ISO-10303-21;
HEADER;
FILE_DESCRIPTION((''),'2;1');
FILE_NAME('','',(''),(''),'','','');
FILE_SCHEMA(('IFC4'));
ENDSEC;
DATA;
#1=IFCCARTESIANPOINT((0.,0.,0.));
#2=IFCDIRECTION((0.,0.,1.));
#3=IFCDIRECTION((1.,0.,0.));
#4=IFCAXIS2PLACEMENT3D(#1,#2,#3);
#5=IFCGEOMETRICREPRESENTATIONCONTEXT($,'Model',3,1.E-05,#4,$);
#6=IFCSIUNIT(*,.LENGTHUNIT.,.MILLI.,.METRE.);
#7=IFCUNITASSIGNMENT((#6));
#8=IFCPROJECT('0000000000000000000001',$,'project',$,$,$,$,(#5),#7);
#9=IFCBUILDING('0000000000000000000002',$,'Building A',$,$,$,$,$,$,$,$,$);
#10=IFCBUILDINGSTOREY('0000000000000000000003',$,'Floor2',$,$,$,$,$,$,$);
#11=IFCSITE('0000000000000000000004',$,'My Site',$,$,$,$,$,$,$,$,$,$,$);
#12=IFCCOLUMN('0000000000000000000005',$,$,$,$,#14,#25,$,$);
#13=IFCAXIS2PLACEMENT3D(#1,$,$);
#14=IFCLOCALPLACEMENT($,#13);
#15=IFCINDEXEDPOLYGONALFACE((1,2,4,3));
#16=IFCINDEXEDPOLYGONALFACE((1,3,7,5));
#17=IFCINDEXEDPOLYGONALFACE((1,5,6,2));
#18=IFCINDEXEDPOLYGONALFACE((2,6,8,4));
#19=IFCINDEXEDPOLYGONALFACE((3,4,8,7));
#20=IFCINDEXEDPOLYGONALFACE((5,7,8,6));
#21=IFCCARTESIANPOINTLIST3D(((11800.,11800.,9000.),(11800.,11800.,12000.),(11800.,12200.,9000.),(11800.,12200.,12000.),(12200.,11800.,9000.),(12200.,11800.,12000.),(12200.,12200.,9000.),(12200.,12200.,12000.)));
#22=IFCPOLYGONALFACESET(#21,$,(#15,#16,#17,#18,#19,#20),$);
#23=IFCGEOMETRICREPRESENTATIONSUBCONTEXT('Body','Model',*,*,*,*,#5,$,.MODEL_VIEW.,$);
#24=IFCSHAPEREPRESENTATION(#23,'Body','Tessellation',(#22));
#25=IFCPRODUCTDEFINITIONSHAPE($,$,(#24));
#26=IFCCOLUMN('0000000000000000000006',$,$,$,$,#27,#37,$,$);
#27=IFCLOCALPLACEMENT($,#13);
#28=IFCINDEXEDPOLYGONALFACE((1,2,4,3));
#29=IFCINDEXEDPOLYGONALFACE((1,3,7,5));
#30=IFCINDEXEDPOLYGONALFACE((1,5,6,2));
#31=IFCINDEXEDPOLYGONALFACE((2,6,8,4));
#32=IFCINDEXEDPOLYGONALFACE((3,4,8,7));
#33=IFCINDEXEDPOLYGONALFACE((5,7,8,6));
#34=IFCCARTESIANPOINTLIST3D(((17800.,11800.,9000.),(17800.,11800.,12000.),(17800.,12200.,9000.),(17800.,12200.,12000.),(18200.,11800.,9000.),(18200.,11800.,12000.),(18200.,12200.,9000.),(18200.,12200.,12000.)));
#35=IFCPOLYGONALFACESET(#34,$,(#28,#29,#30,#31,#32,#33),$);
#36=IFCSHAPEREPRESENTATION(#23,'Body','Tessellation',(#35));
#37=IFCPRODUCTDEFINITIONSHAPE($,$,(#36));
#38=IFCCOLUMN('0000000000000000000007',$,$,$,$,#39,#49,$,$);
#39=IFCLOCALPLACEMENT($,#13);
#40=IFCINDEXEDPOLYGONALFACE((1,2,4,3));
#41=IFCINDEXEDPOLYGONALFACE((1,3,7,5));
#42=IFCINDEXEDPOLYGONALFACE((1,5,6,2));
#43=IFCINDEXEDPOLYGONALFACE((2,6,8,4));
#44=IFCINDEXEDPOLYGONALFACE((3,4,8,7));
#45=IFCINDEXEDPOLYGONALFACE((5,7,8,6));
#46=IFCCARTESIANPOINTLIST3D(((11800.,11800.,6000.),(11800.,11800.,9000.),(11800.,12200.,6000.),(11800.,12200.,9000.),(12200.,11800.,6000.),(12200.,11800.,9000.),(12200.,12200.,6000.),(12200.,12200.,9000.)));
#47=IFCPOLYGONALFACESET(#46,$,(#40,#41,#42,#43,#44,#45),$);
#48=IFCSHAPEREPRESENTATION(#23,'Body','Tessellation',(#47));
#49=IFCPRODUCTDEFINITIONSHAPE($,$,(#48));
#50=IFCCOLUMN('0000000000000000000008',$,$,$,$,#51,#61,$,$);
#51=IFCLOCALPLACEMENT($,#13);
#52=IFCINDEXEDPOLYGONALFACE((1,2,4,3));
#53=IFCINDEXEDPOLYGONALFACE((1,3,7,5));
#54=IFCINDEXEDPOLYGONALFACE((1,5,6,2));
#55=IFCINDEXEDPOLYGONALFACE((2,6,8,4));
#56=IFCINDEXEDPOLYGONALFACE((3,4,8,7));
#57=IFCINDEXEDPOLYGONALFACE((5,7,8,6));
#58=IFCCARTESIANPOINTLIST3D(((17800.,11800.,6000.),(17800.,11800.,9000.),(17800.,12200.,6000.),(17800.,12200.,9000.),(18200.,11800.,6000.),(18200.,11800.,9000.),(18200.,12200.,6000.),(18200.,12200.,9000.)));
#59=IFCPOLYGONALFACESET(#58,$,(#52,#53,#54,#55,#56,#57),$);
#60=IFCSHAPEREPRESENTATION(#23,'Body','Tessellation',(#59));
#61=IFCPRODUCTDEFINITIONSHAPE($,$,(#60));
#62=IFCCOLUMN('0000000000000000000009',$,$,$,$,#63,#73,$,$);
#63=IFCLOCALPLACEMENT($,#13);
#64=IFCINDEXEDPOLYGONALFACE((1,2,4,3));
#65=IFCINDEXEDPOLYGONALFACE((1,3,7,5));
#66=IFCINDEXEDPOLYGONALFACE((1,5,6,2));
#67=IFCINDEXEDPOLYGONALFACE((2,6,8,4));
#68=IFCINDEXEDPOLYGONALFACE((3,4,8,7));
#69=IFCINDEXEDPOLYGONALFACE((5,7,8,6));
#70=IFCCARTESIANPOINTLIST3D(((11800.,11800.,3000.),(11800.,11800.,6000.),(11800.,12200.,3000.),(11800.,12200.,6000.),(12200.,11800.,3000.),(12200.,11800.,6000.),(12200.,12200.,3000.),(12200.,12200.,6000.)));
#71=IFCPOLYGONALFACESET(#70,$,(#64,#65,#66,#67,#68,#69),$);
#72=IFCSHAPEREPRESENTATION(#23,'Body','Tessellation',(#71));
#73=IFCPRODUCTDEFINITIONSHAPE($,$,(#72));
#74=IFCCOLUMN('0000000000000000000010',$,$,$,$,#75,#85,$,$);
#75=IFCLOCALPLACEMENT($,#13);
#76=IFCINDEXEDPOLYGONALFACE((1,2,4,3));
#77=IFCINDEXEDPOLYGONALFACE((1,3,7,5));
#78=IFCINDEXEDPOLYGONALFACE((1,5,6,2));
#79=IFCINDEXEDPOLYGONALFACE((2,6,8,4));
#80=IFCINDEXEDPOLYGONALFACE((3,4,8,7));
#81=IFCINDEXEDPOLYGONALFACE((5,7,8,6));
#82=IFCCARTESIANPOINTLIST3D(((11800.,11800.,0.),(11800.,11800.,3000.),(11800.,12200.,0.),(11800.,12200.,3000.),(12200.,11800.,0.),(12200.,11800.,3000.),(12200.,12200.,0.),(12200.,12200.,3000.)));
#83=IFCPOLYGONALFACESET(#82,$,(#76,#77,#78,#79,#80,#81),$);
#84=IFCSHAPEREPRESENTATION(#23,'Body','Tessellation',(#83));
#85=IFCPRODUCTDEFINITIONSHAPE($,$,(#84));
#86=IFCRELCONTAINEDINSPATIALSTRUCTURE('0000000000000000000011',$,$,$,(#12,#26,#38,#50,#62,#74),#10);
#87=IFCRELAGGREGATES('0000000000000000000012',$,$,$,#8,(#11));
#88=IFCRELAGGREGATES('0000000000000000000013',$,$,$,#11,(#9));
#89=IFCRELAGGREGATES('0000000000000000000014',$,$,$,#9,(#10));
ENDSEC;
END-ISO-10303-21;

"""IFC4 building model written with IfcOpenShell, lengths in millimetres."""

from ifc_helpers import new_model, si_unit, frame, origin_with_axes, place, context, subcontext, project, spatial, line, indexed_curve, outline, extrude, element, save


model = new_model("IFC4")

# Units and contexts
model_context = context("Model", 3, precision=1e-05, world=origin_with_axes())
body_context = subcontext(model_context, "Body", "Model", "MODEL_VIEW")
ifc_project = project(units=[si_unit("LENGTHUNIT", "METRE", prefix="MILLI")], contexts=[model_context])

# Site, building, storey
site = spatial("IfcSite", under=ifc_project, Name="My Site")
building = spatial("IfcBuilding", under=site, Name="Building A")
storey = spatial("IfcBuildingStorey", under=building, Name="Floor2")

# Columns
for number, where, z_axis, x_axis in (
    (1, (12000.0, 12000.0, 9000.0), (0.0, 0.0, 1.0), (1.0, 0.0, 0.0)),
    (2, (18000.0, 12000.0, 9000.0), (0.0, 0.0, 1.0), (1.0, 0.0, 0.0)),
    (3, (12000.0, 12000.0, 6000.0), (0.0, 0.0, 1.0), (1.0, 0.0, 0.0)),
    (4, (18000.0, 12000.0, 6000.0), (0.0, 0.0, 1.0), (1.0, 0.0, 0.0)),
    (5, (12000.0, 12000.0, 3000.0), (0.0, 0.0, 1.0), (1.0, 0.0, 0.0)),
    (6, (12000.0, 12000.0, 0.0), (0.0, 0.0, 1.0), (1.0, 0.0, 0.0)),
):
    element("IfcColumn", number, at=place(None, frame(where, z_axis=z_axis, x_axis=x_axis)), inside=storey, context=body_context, shape_type="SweptSolid", body=[
        extrude(outline(indexed_curve([(-200.0, -200.0), (200.0, -200.0), (200.0, 200.0), (-200.0, 200.0)], segments=[line(1, 2, 3, 4, 1)])), origin_with_axes(), (0.0, 0.0, 1.0), 3000.0),
    ])

save(model, "model.ifc")
